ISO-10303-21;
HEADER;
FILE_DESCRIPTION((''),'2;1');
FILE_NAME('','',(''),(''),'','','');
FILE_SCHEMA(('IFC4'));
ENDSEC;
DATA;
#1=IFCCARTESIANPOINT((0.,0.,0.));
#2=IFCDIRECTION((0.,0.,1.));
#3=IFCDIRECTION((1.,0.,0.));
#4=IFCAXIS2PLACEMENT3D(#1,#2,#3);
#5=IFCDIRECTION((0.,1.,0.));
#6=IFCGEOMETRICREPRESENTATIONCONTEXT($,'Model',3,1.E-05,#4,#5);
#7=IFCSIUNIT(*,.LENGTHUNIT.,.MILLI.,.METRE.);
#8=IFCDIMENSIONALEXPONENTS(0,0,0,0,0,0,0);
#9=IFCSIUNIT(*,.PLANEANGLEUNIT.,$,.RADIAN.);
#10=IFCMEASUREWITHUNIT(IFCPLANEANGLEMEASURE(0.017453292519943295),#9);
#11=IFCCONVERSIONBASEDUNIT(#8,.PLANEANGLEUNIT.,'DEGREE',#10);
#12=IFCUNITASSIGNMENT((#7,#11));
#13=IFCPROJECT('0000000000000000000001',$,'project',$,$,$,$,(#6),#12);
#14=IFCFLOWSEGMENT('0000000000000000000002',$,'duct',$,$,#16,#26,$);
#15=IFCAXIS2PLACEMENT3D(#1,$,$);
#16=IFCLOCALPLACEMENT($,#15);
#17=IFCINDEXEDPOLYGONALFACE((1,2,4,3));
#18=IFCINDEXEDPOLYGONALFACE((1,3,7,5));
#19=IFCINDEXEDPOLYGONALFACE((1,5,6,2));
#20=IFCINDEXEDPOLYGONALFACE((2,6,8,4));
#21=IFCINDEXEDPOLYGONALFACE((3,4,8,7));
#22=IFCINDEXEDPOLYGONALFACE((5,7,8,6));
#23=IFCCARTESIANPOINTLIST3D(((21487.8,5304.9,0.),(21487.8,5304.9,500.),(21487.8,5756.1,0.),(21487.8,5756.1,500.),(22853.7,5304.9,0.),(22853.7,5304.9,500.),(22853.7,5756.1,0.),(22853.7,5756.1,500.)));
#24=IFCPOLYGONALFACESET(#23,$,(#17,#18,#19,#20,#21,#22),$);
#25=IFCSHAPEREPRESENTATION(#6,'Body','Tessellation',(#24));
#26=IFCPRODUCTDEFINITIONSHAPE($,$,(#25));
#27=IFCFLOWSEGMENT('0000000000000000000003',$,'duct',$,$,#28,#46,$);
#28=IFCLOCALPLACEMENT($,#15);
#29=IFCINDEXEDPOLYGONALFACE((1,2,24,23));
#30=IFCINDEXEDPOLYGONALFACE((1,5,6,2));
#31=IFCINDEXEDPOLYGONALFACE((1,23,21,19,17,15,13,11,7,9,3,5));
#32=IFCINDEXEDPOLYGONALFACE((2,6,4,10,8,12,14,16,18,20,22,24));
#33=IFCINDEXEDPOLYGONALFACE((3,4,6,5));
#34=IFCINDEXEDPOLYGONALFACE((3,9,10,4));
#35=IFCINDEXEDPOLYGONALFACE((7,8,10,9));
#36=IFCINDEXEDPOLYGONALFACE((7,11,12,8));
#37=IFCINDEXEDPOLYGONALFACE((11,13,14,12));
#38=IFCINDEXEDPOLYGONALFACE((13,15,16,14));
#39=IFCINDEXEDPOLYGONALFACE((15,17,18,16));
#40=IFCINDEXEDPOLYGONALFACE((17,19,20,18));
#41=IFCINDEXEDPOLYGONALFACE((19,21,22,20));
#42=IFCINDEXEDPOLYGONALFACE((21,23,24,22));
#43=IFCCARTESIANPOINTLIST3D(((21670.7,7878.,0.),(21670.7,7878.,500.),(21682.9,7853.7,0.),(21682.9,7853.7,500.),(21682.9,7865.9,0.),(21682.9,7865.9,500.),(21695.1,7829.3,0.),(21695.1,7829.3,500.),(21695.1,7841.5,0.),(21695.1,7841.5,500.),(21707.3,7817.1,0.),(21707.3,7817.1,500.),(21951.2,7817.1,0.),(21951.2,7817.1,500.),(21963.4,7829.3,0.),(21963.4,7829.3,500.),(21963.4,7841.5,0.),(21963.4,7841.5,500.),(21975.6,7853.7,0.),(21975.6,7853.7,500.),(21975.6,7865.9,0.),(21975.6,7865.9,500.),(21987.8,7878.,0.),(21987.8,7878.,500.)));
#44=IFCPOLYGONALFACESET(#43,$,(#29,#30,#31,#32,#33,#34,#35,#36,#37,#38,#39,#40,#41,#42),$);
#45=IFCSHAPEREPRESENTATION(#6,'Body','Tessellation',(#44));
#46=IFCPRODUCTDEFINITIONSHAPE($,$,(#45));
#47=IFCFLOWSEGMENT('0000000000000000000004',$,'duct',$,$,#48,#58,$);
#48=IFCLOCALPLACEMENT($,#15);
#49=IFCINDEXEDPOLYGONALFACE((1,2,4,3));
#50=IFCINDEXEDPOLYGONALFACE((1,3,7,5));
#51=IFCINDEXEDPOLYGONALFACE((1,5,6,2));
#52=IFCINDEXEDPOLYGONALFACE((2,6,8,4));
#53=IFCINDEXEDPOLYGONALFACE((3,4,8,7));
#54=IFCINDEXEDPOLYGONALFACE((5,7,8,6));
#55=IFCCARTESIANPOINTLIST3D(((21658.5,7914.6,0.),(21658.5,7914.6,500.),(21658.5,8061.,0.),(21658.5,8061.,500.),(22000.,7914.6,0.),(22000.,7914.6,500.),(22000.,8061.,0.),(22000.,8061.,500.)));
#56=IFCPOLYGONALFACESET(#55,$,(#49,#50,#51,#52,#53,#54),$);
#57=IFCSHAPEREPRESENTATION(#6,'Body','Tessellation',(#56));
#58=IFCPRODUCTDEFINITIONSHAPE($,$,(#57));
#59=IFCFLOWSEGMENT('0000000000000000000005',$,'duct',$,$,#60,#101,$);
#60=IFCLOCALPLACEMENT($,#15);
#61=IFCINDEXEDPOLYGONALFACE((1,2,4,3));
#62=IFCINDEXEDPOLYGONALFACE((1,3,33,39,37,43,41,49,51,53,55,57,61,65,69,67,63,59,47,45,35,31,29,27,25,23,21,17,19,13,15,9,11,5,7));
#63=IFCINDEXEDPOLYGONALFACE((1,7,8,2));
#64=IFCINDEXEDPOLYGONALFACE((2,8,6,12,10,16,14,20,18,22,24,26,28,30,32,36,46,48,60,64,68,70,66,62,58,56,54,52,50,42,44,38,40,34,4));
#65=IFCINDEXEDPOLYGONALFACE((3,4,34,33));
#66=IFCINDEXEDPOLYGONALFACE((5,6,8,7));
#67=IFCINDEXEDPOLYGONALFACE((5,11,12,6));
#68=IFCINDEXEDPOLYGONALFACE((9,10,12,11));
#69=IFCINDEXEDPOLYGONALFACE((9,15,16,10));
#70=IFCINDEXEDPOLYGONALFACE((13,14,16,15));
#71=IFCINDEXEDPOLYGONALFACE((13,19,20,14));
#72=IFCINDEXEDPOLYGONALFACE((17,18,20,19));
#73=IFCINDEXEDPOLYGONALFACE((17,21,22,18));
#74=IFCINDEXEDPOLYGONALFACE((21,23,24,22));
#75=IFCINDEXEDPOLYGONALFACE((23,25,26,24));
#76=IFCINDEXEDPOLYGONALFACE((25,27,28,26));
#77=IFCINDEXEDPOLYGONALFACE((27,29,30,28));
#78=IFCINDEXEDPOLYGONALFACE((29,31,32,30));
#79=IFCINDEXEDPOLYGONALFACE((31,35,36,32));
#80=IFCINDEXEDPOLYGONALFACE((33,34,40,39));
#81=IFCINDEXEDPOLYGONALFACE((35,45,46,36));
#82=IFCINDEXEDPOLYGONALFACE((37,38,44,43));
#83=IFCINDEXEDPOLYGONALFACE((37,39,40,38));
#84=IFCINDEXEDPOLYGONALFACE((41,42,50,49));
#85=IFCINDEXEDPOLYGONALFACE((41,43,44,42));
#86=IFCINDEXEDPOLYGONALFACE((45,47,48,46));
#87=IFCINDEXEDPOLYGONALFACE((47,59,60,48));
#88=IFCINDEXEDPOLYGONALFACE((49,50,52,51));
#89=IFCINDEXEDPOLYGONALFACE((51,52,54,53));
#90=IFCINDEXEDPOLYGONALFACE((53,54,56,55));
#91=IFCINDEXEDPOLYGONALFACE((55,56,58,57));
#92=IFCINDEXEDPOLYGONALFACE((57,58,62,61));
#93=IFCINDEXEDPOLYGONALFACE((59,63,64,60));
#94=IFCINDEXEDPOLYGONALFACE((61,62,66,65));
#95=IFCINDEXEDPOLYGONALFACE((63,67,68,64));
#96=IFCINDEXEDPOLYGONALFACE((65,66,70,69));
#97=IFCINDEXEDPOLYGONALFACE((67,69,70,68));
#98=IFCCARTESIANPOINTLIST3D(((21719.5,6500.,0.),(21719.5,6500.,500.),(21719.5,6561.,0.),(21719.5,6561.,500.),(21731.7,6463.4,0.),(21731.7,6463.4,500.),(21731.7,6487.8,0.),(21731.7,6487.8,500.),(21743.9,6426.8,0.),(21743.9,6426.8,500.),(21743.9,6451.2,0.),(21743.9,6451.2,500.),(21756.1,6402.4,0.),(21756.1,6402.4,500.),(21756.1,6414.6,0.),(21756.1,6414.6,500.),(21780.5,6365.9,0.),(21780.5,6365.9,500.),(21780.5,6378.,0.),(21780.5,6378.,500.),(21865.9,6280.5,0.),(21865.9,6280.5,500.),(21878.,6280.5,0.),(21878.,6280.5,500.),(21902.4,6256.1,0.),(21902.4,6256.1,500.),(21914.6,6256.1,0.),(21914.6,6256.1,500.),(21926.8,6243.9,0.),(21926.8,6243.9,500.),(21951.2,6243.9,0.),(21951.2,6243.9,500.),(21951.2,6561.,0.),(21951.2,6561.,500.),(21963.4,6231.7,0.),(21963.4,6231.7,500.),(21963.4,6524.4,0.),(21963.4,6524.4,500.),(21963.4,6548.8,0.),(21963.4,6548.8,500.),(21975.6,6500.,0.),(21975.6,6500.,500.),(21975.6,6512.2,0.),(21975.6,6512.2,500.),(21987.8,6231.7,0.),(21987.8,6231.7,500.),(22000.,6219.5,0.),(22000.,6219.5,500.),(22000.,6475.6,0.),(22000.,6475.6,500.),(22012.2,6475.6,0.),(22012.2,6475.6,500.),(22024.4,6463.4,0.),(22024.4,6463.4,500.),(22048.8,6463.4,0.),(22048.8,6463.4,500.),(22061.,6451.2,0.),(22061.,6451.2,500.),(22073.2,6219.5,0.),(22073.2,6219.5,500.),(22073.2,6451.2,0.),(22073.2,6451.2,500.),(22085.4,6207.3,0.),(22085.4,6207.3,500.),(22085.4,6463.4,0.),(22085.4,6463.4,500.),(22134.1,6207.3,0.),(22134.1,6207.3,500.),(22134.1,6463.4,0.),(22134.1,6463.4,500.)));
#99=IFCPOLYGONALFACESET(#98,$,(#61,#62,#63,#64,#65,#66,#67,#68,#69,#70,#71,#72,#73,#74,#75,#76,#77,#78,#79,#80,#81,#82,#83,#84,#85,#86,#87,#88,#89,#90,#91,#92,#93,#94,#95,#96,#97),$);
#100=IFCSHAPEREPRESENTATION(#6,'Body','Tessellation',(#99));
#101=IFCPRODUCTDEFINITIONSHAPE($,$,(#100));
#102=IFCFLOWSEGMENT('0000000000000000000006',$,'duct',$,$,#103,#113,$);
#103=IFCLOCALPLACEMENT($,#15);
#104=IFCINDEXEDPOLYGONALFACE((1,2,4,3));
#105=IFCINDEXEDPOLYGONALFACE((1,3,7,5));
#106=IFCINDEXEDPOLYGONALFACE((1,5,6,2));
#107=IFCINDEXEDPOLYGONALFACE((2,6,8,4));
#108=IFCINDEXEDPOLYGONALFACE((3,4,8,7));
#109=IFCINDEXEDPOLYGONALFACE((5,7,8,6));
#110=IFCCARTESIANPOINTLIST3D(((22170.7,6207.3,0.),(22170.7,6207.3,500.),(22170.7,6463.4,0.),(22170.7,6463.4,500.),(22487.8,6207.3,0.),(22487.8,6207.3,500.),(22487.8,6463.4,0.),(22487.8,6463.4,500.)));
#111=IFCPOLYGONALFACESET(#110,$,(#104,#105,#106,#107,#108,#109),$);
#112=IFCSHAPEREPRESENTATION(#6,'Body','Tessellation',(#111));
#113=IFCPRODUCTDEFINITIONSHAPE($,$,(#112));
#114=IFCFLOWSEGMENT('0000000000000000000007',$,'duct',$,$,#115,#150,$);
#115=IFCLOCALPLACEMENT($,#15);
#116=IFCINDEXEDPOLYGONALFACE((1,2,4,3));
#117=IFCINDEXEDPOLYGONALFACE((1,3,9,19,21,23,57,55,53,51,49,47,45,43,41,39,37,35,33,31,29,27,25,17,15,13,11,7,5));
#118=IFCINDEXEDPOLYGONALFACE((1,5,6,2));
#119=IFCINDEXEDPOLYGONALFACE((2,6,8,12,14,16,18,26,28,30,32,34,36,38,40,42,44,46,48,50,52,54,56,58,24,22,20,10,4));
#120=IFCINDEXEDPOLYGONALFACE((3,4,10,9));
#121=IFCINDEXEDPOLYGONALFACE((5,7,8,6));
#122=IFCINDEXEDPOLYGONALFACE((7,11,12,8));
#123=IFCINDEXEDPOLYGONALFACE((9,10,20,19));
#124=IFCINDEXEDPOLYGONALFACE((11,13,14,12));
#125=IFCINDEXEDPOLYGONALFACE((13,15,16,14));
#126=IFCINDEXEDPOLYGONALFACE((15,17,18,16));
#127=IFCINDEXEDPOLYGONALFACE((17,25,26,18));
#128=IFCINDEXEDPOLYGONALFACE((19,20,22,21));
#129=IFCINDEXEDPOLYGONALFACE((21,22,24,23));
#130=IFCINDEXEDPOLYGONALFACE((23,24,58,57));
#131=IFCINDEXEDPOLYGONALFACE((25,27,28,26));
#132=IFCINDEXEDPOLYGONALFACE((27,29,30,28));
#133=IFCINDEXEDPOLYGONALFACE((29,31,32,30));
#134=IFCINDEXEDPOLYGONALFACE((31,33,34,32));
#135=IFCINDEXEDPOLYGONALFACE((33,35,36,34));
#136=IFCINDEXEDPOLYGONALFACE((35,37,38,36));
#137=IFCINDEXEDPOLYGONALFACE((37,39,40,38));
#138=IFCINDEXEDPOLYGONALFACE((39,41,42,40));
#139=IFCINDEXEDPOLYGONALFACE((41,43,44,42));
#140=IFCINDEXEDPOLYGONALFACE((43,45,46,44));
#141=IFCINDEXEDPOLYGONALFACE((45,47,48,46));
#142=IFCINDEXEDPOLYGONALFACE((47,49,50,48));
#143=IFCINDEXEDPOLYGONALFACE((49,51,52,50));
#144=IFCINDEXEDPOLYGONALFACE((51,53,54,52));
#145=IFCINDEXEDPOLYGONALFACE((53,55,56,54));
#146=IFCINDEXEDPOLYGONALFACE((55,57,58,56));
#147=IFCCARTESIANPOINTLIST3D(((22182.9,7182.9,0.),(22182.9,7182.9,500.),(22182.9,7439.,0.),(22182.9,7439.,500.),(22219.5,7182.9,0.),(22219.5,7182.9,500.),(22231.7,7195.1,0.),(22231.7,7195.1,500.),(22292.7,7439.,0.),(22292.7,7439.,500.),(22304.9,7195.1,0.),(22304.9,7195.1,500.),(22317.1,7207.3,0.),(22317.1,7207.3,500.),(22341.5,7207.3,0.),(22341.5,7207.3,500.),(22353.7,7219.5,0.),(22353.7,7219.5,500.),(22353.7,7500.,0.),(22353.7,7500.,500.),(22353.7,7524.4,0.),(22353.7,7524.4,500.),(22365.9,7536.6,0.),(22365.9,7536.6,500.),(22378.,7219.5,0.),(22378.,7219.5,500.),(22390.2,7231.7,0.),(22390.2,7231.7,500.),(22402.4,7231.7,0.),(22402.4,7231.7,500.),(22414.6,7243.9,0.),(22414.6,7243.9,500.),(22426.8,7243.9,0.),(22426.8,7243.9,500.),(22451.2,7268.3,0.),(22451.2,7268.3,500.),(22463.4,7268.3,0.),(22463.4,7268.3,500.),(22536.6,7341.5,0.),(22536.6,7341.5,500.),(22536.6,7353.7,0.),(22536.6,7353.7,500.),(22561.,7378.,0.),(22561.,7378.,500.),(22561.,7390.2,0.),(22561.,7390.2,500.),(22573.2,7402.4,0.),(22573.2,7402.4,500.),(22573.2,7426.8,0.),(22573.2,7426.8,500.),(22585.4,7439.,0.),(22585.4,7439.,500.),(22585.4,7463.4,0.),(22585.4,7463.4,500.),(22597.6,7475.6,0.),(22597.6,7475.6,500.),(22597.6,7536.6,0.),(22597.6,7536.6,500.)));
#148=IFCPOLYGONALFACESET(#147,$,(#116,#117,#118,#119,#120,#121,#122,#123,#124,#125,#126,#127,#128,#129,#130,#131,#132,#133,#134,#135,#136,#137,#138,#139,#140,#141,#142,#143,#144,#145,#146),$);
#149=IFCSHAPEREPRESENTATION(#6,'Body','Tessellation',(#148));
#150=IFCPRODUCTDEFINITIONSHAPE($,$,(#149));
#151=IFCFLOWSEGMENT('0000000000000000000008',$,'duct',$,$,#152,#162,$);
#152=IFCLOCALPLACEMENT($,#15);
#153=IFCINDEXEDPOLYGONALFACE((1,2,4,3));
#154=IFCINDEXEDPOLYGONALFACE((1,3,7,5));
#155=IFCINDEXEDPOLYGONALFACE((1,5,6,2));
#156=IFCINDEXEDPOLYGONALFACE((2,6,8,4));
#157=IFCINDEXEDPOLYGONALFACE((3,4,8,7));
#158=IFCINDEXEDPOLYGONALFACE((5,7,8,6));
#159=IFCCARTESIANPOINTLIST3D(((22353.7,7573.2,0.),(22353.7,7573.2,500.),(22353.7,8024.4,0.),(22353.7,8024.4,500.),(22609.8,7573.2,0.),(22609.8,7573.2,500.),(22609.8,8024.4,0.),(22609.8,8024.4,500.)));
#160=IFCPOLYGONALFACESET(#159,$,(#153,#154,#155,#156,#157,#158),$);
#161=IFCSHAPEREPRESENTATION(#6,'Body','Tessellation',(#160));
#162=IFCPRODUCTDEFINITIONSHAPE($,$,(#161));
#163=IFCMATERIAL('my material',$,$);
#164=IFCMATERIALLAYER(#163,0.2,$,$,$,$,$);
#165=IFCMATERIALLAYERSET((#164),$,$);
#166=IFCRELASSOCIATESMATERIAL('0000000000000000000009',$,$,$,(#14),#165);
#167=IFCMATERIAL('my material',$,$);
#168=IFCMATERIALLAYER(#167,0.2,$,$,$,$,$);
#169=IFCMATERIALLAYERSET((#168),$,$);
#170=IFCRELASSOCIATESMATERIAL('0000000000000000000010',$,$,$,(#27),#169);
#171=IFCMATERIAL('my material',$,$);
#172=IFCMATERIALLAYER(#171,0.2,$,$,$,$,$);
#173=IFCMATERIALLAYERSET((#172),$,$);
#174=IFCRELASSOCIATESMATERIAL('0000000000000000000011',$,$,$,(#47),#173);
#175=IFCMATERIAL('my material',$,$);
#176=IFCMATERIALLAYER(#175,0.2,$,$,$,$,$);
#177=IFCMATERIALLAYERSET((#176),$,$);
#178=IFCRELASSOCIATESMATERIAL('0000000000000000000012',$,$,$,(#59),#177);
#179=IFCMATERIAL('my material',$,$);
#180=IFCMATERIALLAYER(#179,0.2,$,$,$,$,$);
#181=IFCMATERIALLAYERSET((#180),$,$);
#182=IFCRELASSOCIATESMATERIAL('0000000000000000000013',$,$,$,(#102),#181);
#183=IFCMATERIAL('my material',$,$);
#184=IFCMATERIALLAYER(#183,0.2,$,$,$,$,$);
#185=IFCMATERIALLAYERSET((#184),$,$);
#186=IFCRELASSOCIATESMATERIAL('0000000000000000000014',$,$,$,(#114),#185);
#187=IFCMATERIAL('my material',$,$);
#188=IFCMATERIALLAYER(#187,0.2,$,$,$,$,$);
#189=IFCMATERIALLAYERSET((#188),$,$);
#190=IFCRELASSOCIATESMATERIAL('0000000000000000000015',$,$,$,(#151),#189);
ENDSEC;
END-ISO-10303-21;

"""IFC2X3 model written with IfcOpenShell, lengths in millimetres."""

from ifc_helpers import new_model, entity, si_unit, converted_unit, direction, origin_with_axes, place, context, project, polyline, outline, extrude, material, layer, layer_set, layer_usage, element, save


model = new_model("IFC2X3")

# Units and contexts
model_context = context("Model", 3, precision=1e-05, world=origin_with_axes(), true_north=direction((0.0, 1.0, 0.0)))
ifc_project = project(units=[si_unit("LENGTHUNIT", "METRE", prefix="MILLI"), converted_unit("PLANEANGLEUNIT", "DEGREE", entity("IfcPlaneAngleMeasure", 0.017453292519943295), si_unit("PLANEANGLEUNIT", "RADIAN"), dimensions=[0, 0, 0, 0, 0, 0, 0])], contexts=[model_context])

# Flow segments
ifc_material_1 = material(Name="my material")
ifc_layer_1 = layer(ifc_material_1, 0.2)
ifc_layer_set_1 = layer_set([ifc_layer_1])
ifc_layer_usage_1 = layer_usage(ifc_layer_set_1, "AXIS2", "POSITIVE", -0.1)
flow_segment_1_placement = place(None, origin_with_axes())
element("IfcFlowSegment", 1, at=flow_segment_1_placement, material=ifc_layer_usage_1, Name="duct", context=model_context, shape_type="SweptSolid", body=[
    extrude(outline(polyline([(21487.8, 5304.9), (22853.7, 5304.9), (22853.7, 5756.1), (21487.8, 5756.1), (21487.8, 5304.9)])), origin_with_axes(), (0.0, 0.0, 1.0), 500.0),
])
ifc_material_2 = material(Name="my material")
ifc_layer_2 = layer(ifc_material_2, 0.2)
ifc_layer_set_2 = layer_set([ifc_layer_2])
ifc_layer_usage_2 = layer_usage(ifc_layer_set_2, "AXIS2", "POSITIVE", -0.1)
flow_segment_2_placement = place(None, origin_with_axes())
element("IfcFlowSegment", 2, at=flow_segment_2_placement, material=ifc_layer_usage_2, Name="duct", context=model_context, shape_type="SweptSolid", body=[
    extrude(outline(polyline([(21670.7, 7878.0), (21682.9, 7865.9), (21682.9, 7853.7), (21695.1, 7841.5), (21695.1, 7829.3), (21707.3, 7817.1), (21951.2, 7817.1), (21963.4, 7829.3), (21963.4, 7841.5), (21975.6, 7853.7), (21975.6, 7865.9), (21987.8, 7878.0), (21670.7, 7878.0)])), origin_with_axes(), (0.0, 0.0, 1.0), 500.0),
])
ifc_material_3 = material(Name="my material")
ifc_layer_3 = layer(ifc_material_3, 0.2)
ifc_layer_set_3 = layer_set([ifc_layer_3])
ifc_layer_usage_3 = layer_usage(ifc_layer_set_3, "AXIS2", "POSITIVE", -0.1)
flow_segment_3_placement = place(None, origin_with_axes())
element("IfcFlowSegment", 3, at=flow_segment_3_placement, material=ifc_layer_usage_3, Name="duct", context=model_context, shape_type="SweptSolid", body=[
    extrude(outline(polyline([(21658.5, 7914.6), (22000.0, 7914.6), (22000.0, 8061.0), (21658.5, 8061.0), (21658.5, 7914.6)])), origin_with_axes(), (0.0, 0.0, 1.0), 500.0),
])
ifc_material_4 = material(Name="my material")
ifc_layer_4 = layer(ifc_material_4, 0.2)
ifc_layer_set_4 = layer_set([ifc_layer_4])
ifc_layer_usage_4 = layer_usage(ifc_layer_set_4, "AXIS2", "POSITIVE", -0.1)
flow_segment_4_placement = place(None, origin_with_axes())
element("IfcFlowSegment", 4, at=flow_segment_4_placement, material=ifc_layer_usage_4, Name="duct", context=model_context, shape_type="SweptSolid", body=[
    extrude(outline(polyline([(21719.5, 6500.0), (21731.7, 6487.8), (21731.7, 6463.4), (21743.9, 6451.2), (21743.9, 6426.8), (21756.1, 6414.6), (21756.1, 6402.4), (21780.5, 6378.0), (21780.5, 6365.9), (21865.9, 6280.5), (21878.0, 6280.5), (21902.4, 6256.1), (21914.6, 6256.1), (21926.8, 6243.9), (21951.2, 6243.9), (21963.4, 6231.7), (21987.8, 6231.7), (22000.0, 6219.5), (22073.2, 6219.5), (22085.4, 6207.3), (22134.1, 6207.3), (22134.1, 6463.4), (22085.4, 6463.4), (22073.2, 6451.2), (22061.0, 6451.2), (22048.8, 6463.4), (22024.4, 6463.4), (22012.2, 6475.6), (22000.0, 6475.6), (21975.6, 6500.0), (21975.6, 6512.2), (21963.4, 6524.4), (21963.4, 6548.8), (21951.2, 6561.0), (21719.5, 6561.0), (21719.5, 6500.0)])), origin_with_axes(), (0.0, 0.0, 1.0), 500.0),
])
ifc_material_5 = material(Name="my material")
ifc_layer_5 = layer(ifc_material_5, 0.2)
ifc_layer_set_5 = layer_set([ifc_layer_5])
ifc_layer_usage_5 = layer_usage(ifc_layer_set_5, "AXIS2", "POSITIVE", -0.1)
flow_segment_5_placement = place(None, origin_with_axes())
element("IfcFlowSegment", 5, at=flow_segment_5_placement, material=ifc_layer_usage_5, Name="duct", context=model_context, shape_type="SweptSolid", body=[
    extrude(outline(polyline([(22170.7, 6207.3), (22487.8, 6207.3), (22487.8, 6463.4), (22170.7, 6463.4), (22170.7, 6207.3)])), origin_with_axes(), (0.0, 0.0, 1.0), 500.0),
])
ifc_material_6 = material(Name="my material")
ifc_layer_6 = layer(ifc_material_6, 0.2)
ifc_layer_set_6 = layer_set([ifc_layer_6])
ifc_layer_usage_6 = layer_usage(ifc_layer_set_6, "AXIS2", "POSITIVE", -0.1)
flow_segment_6_placement = place(None, origin_with_axes())
element("IfcFlowSegment", 6, at=flow_segment_6_placement, material=ifc_layer_usage_6, Name="duct", context=model_context, shape_type="SweptSolid", body=[
    extrude(outline(polyline([(22182.9, 7182.9), (22219.5, 7182.9), (22231.7, 7195.1), (22304.9, 7195.1), (22317.1, 7207.3), (22341.5, 7207.3), (22353.7, 7219.5), (22378.0, 7219.5), (22390.2, 7231.7), (22402.4, 7231.7), (22414.6, 7243.9), (22426.8, 7243.9), (22451.2, 7268.3), (22463.4, 7268.3), (22536.6, 7341.5), (22536.6, 7353.7), (22561.0, 7378.0), (22561.0, 7390.2), (22573.2, 7402.4), (22573.2, 7426.8), (22585.4, 7439.0), (22585.4, 7463.4), (22597.6, 7475.6), (22597.6, 7536.6), (22365.9, 7536.6), (22353.7, 7524.4), (22353.7, 7500.0), (22292.7, 7439.0), (22182.9, 7439.0), (22182.9, 7182.9)])), origin_with_axes(), (0.0, 0.0, 1.0), 500.0),
])
ifc_material_7 = material(Name="my material")
ifc_layer_7 = layer(ifc_material_7, 0.2)
ifc_layer_set_7 = layer_set([ifc_layer_7])
ifc_layer_usage_7 = layer_usage(ifc_layer_set_7, "AXIS2", "POSITIVE", -0.1)
flow_segment_7_placement = place(None, origin_with_axes())
element("IfcFlowSegment", 7, at=flow_segment_7_placement, material=ifc_layer_usage_7, Name="duct", context=model_context, shape_type="SweptSolid", body=[
    extrude(outline(polyline([(22353.7, 7573.2), (22609.8, 7573.2), (22609.8, 8024.4), (22353.7, 8024.4), (22353.7, 7573.2)])), origin_with_axes(), (0.0, 0.0, 1.0), 500.0),
])

save(model, "model.ifc")
